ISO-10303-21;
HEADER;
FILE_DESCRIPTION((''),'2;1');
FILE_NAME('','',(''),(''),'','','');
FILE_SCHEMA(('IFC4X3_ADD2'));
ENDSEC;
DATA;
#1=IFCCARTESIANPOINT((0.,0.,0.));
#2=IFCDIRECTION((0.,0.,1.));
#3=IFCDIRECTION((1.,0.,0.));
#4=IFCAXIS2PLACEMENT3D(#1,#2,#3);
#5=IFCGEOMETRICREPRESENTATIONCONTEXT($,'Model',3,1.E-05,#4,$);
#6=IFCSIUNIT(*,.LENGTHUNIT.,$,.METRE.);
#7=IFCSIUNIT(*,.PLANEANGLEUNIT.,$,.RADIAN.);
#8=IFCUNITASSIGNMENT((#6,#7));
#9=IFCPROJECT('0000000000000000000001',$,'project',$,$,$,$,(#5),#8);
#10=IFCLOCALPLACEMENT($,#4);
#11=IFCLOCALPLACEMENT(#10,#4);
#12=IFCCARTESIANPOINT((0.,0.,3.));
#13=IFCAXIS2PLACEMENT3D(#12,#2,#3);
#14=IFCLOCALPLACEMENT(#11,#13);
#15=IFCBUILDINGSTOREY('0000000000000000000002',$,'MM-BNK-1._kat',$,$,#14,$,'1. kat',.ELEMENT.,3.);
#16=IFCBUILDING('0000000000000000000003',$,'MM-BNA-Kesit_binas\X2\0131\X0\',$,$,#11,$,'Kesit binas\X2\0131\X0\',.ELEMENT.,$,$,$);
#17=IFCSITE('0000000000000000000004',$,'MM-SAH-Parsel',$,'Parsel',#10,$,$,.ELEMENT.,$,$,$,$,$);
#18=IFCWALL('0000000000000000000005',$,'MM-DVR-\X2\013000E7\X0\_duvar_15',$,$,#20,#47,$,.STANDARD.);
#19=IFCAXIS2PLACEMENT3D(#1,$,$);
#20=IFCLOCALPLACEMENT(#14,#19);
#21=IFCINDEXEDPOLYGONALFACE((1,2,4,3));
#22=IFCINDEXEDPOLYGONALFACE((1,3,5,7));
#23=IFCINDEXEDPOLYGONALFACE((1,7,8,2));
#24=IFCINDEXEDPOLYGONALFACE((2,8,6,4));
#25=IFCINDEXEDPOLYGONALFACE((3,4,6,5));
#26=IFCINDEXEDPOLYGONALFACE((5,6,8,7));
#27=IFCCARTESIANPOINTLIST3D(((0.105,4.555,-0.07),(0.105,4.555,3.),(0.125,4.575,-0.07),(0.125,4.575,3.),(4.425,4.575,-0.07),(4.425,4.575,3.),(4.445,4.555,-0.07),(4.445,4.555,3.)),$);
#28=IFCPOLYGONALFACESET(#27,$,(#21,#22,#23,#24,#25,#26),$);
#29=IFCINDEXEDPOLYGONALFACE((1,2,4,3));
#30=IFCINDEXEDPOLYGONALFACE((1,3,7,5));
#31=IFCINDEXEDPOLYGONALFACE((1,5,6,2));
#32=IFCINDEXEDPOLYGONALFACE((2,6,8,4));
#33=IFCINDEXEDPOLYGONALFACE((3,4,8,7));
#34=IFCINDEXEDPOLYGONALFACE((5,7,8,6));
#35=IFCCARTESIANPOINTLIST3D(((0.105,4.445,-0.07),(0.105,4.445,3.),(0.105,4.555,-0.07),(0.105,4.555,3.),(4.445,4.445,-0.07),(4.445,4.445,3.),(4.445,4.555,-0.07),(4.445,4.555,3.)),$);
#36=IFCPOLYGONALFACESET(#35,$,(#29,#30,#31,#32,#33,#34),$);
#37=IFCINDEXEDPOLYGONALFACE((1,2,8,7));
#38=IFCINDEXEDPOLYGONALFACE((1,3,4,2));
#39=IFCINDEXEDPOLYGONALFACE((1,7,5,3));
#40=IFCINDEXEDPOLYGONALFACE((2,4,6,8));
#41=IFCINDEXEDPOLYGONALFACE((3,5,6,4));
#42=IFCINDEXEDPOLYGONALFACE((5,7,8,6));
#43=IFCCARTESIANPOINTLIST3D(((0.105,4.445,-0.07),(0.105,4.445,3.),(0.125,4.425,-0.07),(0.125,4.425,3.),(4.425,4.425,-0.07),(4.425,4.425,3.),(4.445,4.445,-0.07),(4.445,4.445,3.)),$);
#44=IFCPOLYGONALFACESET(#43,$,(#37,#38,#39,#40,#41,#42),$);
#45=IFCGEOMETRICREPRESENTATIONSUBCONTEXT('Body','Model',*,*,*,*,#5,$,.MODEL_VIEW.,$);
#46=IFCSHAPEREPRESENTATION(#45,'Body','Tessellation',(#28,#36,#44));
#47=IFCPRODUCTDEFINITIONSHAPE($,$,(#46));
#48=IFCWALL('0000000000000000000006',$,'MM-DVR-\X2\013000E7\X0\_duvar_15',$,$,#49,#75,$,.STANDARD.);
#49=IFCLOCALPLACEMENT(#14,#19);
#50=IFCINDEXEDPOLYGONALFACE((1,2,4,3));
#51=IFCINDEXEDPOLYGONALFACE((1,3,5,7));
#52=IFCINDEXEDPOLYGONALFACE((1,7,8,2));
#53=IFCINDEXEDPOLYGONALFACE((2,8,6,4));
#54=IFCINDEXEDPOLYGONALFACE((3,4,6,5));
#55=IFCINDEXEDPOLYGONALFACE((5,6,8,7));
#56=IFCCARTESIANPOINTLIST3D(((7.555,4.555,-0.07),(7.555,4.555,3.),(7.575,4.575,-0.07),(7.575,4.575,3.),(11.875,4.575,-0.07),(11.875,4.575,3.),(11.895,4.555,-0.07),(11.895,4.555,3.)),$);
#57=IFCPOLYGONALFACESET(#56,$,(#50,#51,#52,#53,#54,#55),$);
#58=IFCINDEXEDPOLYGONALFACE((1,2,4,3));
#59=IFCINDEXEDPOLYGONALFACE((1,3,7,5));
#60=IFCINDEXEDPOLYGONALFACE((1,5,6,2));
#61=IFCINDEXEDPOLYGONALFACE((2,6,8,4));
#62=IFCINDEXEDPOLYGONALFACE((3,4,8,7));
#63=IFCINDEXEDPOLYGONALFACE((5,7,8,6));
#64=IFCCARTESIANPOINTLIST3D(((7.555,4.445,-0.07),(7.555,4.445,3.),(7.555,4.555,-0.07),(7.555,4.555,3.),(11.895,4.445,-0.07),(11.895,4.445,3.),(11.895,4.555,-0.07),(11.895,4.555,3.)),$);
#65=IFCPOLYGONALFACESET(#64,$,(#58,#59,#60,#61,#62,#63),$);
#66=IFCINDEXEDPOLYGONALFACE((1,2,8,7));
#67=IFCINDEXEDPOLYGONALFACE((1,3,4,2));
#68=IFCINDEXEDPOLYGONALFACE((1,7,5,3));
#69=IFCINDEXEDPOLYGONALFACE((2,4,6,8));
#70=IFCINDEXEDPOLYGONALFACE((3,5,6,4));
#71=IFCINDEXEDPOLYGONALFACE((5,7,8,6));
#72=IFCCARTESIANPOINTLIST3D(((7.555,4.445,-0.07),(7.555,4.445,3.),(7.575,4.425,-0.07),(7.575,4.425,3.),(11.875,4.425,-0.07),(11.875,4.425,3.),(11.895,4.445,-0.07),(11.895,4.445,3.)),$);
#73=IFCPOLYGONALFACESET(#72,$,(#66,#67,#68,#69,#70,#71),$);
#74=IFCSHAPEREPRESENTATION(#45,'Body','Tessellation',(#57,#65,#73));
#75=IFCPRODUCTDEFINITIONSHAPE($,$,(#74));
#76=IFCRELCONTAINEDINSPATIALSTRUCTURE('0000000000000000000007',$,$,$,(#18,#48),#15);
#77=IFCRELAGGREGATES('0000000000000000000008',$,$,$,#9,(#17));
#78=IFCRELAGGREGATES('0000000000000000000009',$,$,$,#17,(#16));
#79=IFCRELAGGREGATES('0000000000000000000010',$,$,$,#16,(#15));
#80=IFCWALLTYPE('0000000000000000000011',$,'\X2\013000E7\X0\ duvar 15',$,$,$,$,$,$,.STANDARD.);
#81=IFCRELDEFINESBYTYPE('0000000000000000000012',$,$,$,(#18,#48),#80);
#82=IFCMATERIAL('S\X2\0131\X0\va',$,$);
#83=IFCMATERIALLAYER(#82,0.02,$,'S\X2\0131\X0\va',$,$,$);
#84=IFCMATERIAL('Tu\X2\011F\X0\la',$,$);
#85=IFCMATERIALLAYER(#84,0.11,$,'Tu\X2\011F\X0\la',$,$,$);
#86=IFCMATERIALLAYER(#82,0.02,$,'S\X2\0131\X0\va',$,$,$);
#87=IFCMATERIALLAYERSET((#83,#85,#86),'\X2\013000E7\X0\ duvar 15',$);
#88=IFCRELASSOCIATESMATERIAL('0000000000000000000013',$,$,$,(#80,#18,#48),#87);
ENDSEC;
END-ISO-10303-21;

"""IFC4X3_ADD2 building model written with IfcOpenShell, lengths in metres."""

from ifc_helpers import new_model, si_unit, frame, origin_with_axes, place, context, subcontext, project, spatial, polyline, outline, extrude, material, layer, layer_set, type_object, element, save


model = new_model("IFC4X3_ADD2")

# Units and contexts
model_context = context("Model", 3, precision=1e-05, world=origin_with_axes())
body_context = subcontext(model_context, "Body", "Model", "MODEL_VIEW")
ifc_project = project(units=[si_unit("LENGTHUNIT", "METRE"), si_unit("PLANEANGLEUNIT", "RADIAN")], contexts=[model_context])

# Site, building, storey
site_placement = place(None, origin_with_axes())
site = spatial("IfcSite", under=ifc_project, at=site_placement, Name="MM-SAH-Parsel", ObjectType="Parsel", CompositionType="ELEMENT")
building_placement = place(site_placement, origin_with_axes())
building = spatial("IfcBuilding", under=site, at=building_placement, Name="MM-BNA-Kesit_binası", LongName="Kesit binası", CompositionType="ELEMENT")
storey_placement = place(building_placement, frame((0.0, 0.0, 3.0), z_axis=(0.0, 0.0, 1.0), x_axis=(1.0, 0.0, 0.0)))
storey = spatial("IfcBuildingStorey", under=building, at=storey_placement, Name="MM-BNK-1._kat", LongName="1. kat", CompositionType="ELEMENT", Elevation=3.0)

# Shared definitions
ifc_material_1 = material(Name="Tuğla")

# Shared definitions
ifc_material_2 = material(Name="Sıva")
ifc_layer_1 = layer(ifc_material_2, 0.02, Name="Sıva")
ifc_layer_2 = layer(ifc_material_1, 0.11, Name="Tuğla")
ifc_layer_3 = layer(ifc_material_2, 0.02, Name="Sıva")
ifc_layer_set_1 = layer_set([ifc_layer_1, ifc_layer_2, ifc_layer_3], Name="İç duvar 15")
wall_type_1 = type_object("IfcWallType", Name="İç duvar 15", PredefinedType="STANDARD", material=ifc_layer_set_1)

# Walls
wall_1_placement = place(storey_placement, origin_with_axes())
element("IfcWall", 1, at=wall_1_placement, inside=storey, type_object=wall_type_1, material=ifc_layer_set_1, Name="MM-DVR-İç_duvar_15", PredefinedType="STANDARD", context=body_context, shape_type="SweptSolid", body=[
    extrude(outline(polyline([(0.125, 4.575), (4.425, 4.575), (4.445, 4.555), (0.105, 4.555), (0.125, 4.575)])), frame((0.0, 0.0, -0.07)), (0.0, 0.0, 1.0), 3.07),
    extrude(outline(polyline([(0.105, 4.555), (4.445, 4.555), (4.445, 4.445), (0.105, 4.445), (0.105, 4.555)])), frame((0.0, 0.0, -0.07)), (0.0, 0.0, 1.0), 3.07),
    extrude(outline(polyline([(0.105, 4.445), (4.445, 4.445), (4.425, 4.425), (0.125, 4.425), (0.105, 4.445)])), frame((0.0, 0.0, -0.07)), (0.0, 0.0, 1.0), 3.07),
])
wall_2_placement = place(storey_placement, origin_with_axes())
element("IfcWall", 2, at=wall_2_placement, inside=storey, type_object=wall_type_1, material=ifc_layer_set_1, Name="MM-DVR-İç_duvar_15", PredefinedType="STANDARD", context=body_context, shape_type="SweptSolid", body=[
    extrude(outline(polyline([(7.575, 4.575), (11.875, 4.575), (11.895, 4.555), (7.555, 4.555), (7.575, 4.575)])), frame((0.0, 0.0, -0.07)), (0.0, 0.0, 1.0), 3.07),
    extrude(outline(polyline([(7.555, 4.555), (11.895, 4.555), (11.895, 4.445), (7.555, 4.445), (7.555, 4.555)])), frame((0.0, 0.0, -0.07)), (0.0, 0.0, 1.0), 3.07),
    extrude(outline(polyline([(7.555, 4.445), (11.895, 4.445), (11.875, 4.425), (7.575, 4.425), (7.555, 4.445)])), frame((0.0, 0.0, -0.07)), (0.0, 0.0, 1.0), 3.07),
])

save(model, "model.ifc")
